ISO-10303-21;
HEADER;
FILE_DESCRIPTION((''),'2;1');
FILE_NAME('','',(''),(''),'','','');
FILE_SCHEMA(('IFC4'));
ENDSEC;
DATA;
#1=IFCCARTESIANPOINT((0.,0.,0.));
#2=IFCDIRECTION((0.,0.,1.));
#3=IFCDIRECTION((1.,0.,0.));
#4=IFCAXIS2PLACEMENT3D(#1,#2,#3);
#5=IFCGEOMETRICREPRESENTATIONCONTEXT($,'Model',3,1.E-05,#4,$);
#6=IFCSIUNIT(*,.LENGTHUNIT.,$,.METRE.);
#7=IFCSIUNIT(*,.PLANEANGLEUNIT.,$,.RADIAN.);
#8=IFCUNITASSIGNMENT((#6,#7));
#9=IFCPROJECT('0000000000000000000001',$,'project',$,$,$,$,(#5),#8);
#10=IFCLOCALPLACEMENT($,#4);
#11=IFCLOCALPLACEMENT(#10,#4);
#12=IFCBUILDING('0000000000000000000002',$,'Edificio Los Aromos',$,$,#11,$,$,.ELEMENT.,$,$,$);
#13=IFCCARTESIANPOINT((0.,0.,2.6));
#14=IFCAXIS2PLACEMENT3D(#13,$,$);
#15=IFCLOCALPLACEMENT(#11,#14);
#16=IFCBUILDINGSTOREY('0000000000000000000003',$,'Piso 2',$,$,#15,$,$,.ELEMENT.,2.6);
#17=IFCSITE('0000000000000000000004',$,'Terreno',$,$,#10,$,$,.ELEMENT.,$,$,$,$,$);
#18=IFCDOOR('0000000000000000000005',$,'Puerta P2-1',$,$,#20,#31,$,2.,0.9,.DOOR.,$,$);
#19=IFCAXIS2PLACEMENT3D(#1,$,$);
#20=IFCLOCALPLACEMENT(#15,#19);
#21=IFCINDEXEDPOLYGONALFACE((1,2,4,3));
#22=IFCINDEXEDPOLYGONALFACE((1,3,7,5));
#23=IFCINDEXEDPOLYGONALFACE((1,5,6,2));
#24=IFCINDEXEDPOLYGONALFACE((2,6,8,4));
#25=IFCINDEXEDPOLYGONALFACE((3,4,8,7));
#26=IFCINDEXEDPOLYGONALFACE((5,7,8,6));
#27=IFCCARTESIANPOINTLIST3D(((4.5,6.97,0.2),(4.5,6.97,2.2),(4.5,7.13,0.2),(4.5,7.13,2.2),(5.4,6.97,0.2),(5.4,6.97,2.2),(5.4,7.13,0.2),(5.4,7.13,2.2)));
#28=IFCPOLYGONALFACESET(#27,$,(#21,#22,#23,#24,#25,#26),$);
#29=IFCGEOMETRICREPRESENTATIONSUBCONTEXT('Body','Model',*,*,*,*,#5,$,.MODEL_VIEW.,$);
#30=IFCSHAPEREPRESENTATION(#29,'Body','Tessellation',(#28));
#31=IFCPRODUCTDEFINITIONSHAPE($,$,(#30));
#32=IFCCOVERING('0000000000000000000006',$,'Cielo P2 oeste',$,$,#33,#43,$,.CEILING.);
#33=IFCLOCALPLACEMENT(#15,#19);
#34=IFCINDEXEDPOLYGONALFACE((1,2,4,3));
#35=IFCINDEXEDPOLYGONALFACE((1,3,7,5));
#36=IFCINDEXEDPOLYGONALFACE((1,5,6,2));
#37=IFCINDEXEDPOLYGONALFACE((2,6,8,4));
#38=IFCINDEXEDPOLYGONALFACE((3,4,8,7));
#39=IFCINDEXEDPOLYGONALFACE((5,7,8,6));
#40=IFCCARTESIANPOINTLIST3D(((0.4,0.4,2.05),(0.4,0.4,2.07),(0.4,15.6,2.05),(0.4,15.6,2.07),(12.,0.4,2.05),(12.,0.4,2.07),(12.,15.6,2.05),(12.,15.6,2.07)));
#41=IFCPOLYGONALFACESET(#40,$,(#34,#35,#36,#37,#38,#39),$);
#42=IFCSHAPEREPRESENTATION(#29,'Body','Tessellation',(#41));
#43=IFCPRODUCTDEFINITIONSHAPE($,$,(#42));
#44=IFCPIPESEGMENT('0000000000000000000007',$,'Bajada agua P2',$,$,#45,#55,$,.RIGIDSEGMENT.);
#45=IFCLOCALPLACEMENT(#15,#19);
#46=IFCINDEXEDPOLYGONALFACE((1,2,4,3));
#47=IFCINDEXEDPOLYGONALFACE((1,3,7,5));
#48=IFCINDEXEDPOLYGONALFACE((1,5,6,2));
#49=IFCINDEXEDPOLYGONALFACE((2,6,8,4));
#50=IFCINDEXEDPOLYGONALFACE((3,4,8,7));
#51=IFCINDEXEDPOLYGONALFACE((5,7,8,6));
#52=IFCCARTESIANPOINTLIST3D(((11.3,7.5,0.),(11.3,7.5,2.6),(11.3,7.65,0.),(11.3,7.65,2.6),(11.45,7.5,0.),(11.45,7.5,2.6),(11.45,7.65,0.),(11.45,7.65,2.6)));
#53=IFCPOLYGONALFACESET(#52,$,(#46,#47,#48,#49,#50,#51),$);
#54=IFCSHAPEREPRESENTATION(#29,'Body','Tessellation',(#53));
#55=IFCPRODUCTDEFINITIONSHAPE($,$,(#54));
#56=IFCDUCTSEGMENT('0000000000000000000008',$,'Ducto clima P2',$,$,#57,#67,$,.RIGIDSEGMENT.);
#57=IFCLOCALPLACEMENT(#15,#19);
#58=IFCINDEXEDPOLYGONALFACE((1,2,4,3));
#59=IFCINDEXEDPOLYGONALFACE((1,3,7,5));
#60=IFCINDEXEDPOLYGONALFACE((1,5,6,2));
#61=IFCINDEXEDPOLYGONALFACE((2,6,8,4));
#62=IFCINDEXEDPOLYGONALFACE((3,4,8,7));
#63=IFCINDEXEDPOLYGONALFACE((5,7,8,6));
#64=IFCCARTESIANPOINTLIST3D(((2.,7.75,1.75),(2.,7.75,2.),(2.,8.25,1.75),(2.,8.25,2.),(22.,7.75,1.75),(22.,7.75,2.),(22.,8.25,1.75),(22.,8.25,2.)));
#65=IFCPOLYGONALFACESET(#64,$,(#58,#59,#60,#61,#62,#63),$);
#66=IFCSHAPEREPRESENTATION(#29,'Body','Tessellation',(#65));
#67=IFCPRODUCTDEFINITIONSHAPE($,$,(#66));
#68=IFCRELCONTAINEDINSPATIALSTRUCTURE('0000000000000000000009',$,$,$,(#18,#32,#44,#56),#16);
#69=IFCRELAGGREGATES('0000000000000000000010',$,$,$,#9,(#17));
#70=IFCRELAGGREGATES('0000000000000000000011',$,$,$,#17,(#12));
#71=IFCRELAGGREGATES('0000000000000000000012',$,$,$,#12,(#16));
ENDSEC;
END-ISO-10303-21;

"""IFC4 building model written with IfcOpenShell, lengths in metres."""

from ifc_helpers import new_model, si_unit, frame, frame_2d, origin_with_axes, place, context, subcontext, project, spatial, rectangle, extrude, element, save


model = new_model("IFC4")

# Units and contexts
model_context = context("Model", 3, precision=1e-05, world=origin_with_axes())
body_context = subcontext(model_context, "Body", "Model", "MODEL_VIEW")
ifc_project = project(units=[si_unit("LENGTHUNIT", "METRE"), si_unit("PLANEANGLEUNIT", "RADIAN")], contexts=[model_context])

# Site, building, storey
site_placement = place(None, origin_with_axes())
site = spatial("IfcSite", under=ifc_project, at=site_placement, Name="Terreno", CompositionType="ELEMENT")
building_placement = place(site_placement, origin_with_axes())
building = spatial("IfcBuilding", under=site, at=building_placement, Name="Edificio Los Aromos", CompositionType="ELEMENT")
storey_placement = place(building_placement, frame((0.0, 0.0, 2.6)))
storey = spatial("IfcBuildingStorey", under=building, at=storey_placement, Name="Piso 2", CompositionType="ELEMENT", Elevation=2.6)

# Door
door_placement = place(storey_placement, frame((4.5, 6.97, 0.2)))
element("IfcDoor", 1, at=door_placement, inside=storey, Name="Puerta P2-1", OverallHeight=2.0, OverallWidth=0.9, PredefinedType="DOOR", context=body_context, shape_type="SweptSolid", body=[
    extrude(rectangle(XDim=0.9, YDim=0.16, at=frame_2d((0.45, 0.08))), origin_with_axes(), (0.0, 0.0, 1.0), 2.0),
])

# Covering
covering_placement = place(storey_placement, frame((0.4, 0.4, 2.05)))
element("IfcCovering", 2, at=covering_placement, inside=storey, Name="Cielo P2 oeste", PredefinedType="CEILING", context=body_context, shape_type="SweptSolid", body=[
    extrude(rectangle(XDim=11.6, YDim=15.2, at=frame_2d((5.8, 7.6))), origin_with_axes(), (0.0, 0.0, 1.0), 0.02),
])

# Pipe segment
pipe_segment_placement = place(storey_placement, frame((11.3, 7.5, 0.0)))
element("IfcPipeSegment", 3, at=pipe_segment_placement, inside=storey, Name="Bajada agua P2", PredefinedType="RIGIDSEGMENT", context=body_context, shape_type="SweptSolid", body=[
    extrude(rectangle(XDim=0.15, YDim=0.15, at=frame_2d((0.075, 0.075))), origin_with_axes(), (0.0, 0.0, 1.0), 2.6),
])

# Duct segment
duct_segment_placement = place(storey_placement, frame((2.0, 7.75, 1.75)))
element("IfcDuctSegment", 4, at=duct_segment_placement, inside=storey, Name="Ducto clima P2", PredefinedType="RIGIDSEGMENT", context=body_context, shape_type="SweptSolid", body=[
    extrude(rectangle(XDim=20.0, YDim=0.5, at=frame_2d((10.0, 0.25))), origin_with_axes(), (0.0, 0.0, 1.0), 0.25),
])

save(model, "model.ifc")
